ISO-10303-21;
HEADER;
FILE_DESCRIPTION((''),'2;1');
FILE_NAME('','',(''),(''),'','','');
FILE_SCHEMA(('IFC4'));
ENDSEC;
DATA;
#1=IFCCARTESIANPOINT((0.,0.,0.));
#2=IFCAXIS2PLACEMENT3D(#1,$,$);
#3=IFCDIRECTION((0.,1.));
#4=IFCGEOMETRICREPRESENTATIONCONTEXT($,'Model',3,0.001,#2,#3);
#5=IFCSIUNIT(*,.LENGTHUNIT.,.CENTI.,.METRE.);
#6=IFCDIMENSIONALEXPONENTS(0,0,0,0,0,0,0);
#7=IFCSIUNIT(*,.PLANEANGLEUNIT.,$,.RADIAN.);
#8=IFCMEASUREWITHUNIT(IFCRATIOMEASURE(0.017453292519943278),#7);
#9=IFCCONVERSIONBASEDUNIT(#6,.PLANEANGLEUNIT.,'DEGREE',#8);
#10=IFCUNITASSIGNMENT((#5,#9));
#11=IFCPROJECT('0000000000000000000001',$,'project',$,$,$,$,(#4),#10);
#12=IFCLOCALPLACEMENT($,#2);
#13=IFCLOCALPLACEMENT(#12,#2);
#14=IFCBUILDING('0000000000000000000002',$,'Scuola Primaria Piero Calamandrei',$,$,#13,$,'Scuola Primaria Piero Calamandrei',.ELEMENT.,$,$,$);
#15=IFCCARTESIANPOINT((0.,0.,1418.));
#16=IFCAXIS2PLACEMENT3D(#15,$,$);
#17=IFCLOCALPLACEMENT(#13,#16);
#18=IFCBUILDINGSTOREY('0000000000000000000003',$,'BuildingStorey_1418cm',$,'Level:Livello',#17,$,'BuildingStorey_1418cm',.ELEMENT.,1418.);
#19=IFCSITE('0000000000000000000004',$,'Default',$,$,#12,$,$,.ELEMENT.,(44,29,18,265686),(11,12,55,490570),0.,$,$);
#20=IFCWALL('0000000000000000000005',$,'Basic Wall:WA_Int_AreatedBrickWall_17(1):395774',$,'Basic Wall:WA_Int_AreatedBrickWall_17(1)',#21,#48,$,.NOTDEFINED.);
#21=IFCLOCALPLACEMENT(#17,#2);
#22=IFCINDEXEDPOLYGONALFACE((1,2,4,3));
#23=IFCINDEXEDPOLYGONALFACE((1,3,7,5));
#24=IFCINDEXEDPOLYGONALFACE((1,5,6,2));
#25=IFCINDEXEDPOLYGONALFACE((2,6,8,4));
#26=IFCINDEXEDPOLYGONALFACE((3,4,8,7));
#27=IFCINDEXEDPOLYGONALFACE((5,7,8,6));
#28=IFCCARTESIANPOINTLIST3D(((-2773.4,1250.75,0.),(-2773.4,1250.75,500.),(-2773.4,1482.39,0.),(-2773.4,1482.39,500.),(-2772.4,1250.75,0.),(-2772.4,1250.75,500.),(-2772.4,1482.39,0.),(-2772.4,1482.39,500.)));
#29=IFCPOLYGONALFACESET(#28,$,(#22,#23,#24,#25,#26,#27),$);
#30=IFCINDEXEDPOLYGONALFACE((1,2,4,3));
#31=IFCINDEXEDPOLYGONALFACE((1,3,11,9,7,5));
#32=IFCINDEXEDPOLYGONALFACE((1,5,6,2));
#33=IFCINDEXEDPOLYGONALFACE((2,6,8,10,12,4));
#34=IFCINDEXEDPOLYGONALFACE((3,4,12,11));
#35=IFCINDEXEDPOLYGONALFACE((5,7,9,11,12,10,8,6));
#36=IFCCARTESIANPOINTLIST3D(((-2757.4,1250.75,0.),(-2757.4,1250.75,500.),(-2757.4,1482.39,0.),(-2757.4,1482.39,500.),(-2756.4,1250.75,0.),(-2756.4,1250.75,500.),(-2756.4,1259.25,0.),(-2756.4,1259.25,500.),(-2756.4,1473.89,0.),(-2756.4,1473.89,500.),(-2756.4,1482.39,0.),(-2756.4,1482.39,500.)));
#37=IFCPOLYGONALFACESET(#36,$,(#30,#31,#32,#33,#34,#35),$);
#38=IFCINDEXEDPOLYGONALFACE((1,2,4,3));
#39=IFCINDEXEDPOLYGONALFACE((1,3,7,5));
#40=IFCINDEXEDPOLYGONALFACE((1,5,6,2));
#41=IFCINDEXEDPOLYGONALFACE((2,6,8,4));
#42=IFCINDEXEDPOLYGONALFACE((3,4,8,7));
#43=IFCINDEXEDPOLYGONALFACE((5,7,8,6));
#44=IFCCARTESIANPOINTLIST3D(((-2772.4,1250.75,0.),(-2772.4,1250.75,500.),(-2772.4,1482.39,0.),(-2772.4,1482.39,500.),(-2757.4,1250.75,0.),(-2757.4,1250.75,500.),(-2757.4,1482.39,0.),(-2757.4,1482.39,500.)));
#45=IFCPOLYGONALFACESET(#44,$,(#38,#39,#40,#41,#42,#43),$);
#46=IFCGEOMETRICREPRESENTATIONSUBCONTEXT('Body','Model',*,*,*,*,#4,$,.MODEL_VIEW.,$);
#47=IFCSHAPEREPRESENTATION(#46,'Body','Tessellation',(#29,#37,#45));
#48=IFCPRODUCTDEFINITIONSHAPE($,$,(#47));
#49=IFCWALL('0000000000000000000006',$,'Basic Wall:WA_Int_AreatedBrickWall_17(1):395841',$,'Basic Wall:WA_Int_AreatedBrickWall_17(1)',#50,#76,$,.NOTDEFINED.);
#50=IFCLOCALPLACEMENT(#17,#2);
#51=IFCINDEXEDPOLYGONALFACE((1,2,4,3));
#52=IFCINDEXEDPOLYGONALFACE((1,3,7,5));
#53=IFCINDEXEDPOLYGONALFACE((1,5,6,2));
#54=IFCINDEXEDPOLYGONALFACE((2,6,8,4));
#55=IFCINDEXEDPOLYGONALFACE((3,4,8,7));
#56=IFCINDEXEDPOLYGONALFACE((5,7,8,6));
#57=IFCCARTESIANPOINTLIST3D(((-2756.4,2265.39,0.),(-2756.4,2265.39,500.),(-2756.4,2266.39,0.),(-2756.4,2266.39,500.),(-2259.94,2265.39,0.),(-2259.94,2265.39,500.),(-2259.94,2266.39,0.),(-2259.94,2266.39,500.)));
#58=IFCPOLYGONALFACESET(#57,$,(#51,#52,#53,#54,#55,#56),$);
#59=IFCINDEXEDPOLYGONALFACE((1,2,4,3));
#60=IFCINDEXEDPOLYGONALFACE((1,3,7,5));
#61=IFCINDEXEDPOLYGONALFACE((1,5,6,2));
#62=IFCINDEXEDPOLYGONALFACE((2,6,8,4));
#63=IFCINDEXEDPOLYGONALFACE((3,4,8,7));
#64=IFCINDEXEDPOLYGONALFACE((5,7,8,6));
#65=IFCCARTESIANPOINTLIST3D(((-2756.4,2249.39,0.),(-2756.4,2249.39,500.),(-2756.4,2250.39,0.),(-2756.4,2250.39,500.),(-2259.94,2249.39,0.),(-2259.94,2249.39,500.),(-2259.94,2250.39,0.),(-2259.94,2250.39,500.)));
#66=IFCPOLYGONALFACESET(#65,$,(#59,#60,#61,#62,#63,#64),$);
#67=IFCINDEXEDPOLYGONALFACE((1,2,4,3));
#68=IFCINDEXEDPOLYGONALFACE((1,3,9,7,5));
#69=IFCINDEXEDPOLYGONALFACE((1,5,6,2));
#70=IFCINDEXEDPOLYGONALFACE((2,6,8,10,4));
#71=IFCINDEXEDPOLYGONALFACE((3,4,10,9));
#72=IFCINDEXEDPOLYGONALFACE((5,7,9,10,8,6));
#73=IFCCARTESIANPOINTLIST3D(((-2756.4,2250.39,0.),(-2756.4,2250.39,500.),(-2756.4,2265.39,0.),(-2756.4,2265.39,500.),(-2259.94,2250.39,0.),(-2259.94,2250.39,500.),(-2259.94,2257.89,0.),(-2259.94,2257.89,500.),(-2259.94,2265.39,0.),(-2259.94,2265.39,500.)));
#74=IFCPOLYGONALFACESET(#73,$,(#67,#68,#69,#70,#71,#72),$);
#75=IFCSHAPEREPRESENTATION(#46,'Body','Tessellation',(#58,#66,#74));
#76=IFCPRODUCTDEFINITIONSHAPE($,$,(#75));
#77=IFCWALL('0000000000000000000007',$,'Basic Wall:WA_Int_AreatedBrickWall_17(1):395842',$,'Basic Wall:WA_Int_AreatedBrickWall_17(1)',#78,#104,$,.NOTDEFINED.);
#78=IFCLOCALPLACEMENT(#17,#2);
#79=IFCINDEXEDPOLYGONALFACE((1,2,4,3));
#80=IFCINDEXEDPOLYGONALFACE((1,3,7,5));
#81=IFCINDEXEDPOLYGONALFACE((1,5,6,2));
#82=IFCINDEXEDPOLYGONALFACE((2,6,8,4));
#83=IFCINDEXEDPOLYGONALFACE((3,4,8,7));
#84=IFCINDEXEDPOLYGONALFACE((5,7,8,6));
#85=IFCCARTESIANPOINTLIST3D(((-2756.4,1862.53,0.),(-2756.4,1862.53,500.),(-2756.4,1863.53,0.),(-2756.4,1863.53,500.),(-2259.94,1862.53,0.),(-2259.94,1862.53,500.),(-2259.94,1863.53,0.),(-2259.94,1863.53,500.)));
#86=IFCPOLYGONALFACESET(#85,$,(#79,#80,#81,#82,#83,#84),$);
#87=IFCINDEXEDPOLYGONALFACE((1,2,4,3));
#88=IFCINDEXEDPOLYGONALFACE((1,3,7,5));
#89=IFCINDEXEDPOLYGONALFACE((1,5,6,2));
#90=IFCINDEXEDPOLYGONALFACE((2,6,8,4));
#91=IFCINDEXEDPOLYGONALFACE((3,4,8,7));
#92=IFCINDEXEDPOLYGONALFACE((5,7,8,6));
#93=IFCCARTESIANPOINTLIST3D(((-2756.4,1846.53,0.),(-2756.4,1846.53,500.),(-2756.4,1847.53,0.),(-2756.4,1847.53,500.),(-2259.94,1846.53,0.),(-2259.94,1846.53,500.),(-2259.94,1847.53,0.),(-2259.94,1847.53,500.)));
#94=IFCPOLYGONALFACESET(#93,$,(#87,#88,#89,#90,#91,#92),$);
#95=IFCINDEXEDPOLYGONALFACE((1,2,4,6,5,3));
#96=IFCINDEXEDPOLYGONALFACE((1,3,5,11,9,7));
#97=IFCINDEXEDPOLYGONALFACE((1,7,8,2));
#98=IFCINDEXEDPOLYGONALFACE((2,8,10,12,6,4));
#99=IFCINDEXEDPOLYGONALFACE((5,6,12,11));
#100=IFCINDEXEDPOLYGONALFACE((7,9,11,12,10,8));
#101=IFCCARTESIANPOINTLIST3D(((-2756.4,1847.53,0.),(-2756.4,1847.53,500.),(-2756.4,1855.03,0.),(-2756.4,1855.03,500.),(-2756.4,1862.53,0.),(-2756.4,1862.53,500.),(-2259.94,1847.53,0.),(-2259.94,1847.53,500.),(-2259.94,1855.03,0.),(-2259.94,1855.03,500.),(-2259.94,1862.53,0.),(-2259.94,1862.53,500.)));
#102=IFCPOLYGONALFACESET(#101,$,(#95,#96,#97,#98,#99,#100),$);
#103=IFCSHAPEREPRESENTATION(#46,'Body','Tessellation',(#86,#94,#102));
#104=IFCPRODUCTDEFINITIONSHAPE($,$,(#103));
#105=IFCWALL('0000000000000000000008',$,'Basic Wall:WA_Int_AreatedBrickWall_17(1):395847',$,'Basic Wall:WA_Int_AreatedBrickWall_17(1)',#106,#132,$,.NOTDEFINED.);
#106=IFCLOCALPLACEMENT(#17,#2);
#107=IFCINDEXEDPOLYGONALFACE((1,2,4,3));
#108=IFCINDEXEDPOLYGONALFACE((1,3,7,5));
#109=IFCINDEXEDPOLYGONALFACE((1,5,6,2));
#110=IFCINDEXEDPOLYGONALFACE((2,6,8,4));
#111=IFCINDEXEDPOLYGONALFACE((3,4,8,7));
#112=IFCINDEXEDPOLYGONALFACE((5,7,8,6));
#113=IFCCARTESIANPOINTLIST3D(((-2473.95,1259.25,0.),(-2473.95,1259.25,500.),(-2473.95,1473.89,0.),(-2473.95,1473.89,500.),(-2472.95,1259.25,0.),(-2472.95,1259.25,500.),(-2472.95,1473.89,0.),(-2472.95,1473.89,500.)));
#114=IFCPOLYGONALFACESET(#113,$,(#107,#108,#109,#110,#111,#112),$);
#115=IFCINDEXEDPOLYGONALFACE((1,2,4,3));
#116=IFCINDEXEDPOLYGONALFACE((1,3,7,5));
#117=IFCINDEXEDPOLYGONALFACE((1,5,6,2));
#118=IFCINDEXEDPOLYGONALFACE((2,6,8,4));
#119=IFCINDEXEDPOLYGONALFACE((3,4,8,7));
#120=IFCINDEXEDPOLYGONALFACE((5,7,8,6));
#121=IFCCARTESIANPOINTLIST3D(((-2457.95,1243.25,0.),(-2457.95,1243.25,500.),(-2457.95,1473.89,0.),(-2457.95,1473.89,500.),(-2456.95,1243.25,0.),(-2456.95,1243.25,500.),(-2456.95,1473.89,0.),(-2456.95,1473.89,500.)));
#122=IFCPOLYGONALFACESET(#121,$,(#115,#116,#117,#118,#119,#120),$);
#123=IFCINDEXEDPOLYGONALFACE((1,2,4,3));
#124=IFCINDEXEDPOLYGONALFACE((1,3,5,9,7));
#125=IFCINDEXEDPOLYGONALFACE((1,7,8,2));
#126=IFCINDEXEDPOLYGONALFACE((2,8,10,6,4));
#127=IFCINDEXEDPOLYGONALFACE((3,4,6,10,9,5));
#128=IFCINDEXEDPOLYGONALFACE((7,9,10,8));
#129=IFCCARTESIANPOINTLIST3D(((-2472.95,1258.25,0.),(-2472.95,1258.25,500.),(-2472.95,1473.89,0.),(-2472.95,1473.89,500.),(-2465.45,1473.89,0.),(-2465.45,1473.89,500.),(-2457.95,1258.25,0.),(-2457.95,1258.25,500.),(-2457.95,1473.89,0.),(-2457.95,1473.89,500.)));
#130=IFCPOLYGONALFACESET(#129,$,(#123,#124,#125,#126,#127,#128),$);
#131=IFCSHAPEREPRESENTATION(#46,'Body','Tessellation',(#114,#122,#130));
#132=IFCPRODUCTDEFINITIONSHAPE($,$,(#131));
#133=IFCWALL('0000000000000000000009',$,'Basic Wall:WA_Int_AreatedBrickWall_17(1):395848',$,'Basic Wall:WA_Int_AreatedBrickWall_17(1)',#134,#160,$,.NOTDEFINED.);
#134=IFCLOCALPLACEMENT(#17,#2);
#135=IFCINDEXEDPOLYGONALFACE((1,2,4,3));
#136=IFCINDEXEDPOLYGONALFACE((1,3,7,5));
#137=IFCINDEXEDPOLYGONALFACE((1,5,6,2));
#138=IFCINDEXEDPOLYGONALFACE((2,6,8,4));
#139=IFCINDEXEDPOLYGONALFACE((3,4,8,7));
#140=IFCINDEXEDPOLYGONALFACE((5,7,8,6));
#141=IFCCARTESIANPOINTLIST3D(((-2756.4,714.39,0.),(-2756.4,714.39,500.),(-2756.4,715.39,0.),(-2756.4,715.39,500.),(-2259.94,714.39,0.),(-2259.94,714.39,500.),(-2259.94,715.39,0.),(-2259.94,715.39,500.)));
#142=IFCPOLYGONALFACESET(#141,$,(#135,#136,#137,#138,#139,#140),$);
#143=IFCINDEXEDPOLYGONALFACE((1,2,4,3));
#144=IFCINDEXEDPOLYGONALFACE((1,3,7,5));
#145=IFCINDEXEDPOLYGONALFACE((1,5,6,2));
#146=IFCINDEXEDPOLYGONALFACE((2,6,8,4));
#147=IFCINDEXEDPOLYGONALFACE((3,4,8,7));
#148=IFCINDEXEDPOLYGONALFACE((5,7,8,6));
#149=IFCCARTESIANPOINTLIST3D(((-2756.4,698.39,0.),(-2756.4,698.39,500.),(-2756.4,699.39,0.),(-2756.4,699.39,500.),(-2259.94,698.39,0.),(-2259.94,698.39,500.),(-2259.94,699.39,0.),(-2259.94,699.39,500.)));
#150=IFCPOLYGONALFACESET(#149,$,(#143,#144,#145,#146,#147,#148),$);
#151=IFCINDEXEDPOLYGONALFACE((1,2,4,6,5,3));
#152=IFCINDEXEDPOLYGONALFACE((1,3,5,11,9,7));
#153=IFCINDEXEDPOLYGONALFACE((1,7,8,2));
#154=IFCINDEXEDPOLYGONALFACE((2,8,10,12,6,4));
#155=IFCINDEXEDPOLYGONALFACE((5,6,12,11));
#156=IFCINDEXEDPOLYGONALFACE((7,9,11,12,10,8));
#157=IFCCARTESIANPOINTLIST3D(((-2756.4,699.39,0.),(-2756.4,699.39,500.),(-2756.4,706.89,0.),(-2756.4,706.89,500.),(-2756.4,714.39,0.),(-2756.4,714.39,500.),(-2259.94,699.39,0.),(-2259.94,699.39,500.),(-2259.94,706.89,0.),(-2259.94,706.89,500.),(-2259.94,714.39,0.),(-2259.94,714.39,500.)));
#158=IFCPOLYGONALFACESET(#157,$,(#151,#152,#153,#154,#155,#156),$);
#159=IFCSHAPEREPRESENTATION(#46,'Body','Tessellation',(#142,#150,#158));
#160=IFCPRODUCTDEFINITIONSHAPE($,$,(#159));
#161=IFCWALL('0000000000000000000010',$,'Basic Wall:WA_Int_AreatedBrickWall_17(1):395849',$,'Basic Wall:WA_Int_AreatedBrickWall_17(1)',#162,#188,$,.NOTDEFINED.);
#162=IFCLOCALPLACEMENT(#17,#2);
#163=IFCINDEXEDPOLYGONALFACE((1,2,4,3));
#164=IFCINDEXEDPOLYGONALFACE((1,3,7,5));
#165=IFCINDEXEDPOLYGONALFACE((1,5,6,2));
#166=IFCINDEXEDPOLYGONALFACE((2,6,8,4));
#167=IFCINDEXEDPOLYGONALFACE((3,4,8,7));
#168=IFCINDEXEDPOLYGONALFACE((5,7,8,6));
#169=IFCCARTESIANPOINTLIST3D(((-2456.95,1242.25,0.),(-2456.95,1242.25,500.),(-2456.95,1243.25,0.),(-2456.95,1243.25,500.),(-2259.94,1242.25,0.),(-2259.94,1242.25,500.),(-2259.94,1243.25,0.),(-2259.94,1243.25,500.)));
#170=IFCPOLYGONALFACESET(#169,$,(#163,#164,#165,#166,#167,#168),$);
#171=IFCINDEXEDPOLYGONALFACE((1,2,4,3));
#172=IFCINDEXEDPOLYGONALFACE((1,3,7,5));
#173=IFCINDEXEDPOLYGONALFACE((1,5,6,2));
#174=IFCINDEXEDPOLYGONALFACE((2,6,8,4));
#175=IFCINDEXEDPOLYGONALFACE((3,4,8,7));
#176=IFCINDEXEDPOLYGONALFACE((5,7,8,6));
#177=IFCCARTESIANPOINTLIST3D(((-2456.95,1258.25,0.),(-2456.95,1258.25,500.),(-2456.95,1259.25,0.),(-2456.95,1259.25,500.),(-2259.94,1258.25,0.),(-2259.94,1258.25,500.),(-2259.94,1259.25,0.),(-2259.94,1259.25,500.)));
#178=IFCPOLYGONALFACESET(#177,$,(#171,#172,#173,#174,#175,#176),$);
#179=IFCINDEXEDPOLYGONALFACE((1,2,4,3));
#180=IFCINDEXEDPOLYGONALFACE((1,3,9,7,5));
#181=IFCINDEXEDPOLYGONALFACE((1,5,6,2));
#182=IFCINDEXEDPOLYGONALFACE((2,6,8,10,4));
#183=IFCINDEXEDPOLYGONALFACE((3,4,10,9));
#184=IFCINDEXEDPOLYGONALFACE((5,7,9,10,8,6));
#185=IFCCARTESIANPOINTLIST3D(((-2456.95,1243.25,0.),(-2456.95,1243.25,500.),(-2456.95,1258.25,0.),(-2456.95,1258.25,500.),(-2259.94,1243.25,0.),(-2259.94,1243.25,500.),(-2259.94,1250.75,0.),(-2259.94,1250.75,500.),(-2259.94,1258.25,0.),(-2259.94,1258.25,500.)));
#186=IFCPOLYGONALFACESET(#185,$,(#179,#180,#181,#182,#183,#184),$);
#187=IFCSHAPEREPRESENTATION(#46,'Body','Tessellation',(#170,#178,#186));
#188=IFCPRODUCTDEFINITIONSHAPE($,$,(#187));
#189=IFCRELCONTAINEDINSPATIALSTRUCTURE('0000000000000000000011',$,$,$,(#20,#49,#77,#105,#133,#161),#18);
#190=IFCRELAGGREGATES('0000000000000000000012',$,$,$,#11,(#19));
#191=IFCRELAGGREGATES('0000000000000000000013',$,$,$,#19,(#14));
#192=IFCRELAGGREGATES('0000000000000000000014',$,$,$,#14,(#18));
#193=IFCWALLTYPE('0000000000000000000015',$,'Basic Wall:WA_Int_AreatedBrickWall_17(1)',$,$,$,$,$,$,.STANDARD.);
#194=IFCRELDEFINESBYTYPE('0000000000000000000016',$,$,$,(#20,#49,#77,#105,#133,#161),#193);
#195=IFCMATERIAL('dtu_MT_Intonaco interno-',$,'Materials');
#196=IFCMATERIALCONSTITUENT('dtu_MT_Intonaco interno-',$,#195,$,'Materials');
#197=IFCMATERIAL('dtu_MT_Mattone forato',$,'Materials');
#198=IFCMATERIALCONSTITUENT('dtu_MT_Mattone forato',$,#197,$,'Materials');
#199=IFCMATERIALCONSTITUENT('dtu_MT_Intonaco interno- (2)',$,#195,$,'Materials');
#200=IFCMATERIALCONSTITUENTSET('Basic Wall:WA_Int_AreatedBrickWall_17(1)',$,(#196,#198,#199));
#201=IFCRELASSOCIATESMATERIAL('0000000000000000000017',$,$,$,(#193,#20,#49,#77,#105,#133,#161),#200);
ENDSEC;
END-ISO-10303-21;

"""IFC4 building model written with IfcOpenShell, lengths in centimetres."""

from ifc_helpers import new_model, entity, si_unit, converted_unit, direction, frame, origin, place, context, subcontext, project, spatial, indexed_curve, outline, extrude, material, constituent, constituent_set, type_object, element, save


model = new_model("IFC4")

# Units and contexts
model_context = context("Model", 3, precision=0.001, world=origin(), true_north=direction((0.0, 1.0)))
body_context = subcontext(model_context, "Body", "Model", "MODEL_VIEW")
ifc_project = project(units=[si_unit("LENGTHUNIT", "METRE", prefix="CENTI"), converted_unit("PLANEANGLEUNIT", "DEGREE", entity("IfcRatioMeasure", 0.017453292519943278), si_unit("PLANEANGLEUNIT", "RADIAN"), dimensions=[0, 0, 0, 0, 0, 0, 0])], contexts=[model_context])

# Site, building, storey
site_placement = place(None, origin())
site = spatial("IfcSite", under=ifc_project, at=site_placement, Name="Default", CompositionType="ELEMENT", RefLatitude=(44, 29, 18, 265686), RefLongitude=(11, 12, 55, 490570), RefElevation=0.0)
building_placement = place(site_placement, origin())
building = spatial("IfcBuilding", under=site, at=building_placement, Name="Scuola Primaria Piero Calamandrei", LongName="Scuola Primaria Piero Calamandrei", CompositionType="ELEMENT")
storey_placement = place(building_placement, frame((0.0, 0.0, 1418.0)))
storey = spatial("IfcBuildingStorey", under=building, at=storey_placement, Name="BuildingStorey_1418cm", ObjectType="Level:Livello", LongName="BuildingStorey_1418cm", CompositionType="ELEMENT", Elevation=1418.0)

# Shared definitions
ifc_material_1 = material(Name="dtu_MT_Intonaco interno-", Category="Materials")

# Shared definitions
ifc_constituent_1 = constituent(ifc_material_1, Name="dtu_MT_Intonaco interno-", Category="Materials")
ifc_material_2 = material(Name="dtu_MT_Mattone forato", Category="Materials")
ifc_constituent_2 = constituent(ifc_material_2, Name="dtu_MT_Mattone forato", Category="Materials")
ifc_constituent_3 = constituent(ifc_material_1, Name="dtu_MT_Intonaco interno- (2)", Category="Materials")
ifc_constituent_set_1 = constituent_set(constituents=[ifc_constituent_1, ifc_constituent_2, ifc_constituent_3], Name="Basic Wall:WA_Int_AreatedBrickWall_17(1)")
wall_type_1 = type_object("IfcWallType", Name="Basic Wall:WA_Int_AreatedBrickWall_17(1)", PredefinedType="STANDARD", material=ifc_constituent_set_1)

# Wall
wall_1_placement = place(storey_placement, frame((-2764.9, 1482.39, 0.0), z_axis=(0.0, 0.0, 1.0), x_axis=(0.0, -1.0, 0.0)))
element("IfcWall", 1, at=wall_1_placement, inside=storey, type_object=wall_type_1, material=ifc_constituent_set_1, Name="Basic Wall:WA_Int_AreatedBrickWall_17(1):395774", ObjectType="Basic Wall:WA_Int_AreatedBrickWall_17(1)", PredefinedType="NOTDEFINED", context=body_context, shape_type="SweptSolid", body=[
    extrude(outline(indexed_curve([(-0.5, -115.82), (0.5, -115.82), (0.5, 115.82), (-0.5, 115.82), (-0.5, -115.82)], self_intersect=False)), frame((115.82, -8.0, 0.0), z_axis=(0.0, 0.0, 1.0), x_axis=(0.0, 1.0, 0.0)), (0.0, 0.0, 1.0), 500.0),
    extrude(outline(indexed_curve([(-107.32, -0.33), (107.32, -0.33), (115.82, -0.33), (115.82, 0.67), (-115.82, 0.67), (-115.82, -0.33), (-107.32, -0.33)], self_intersect=False)), frame((115.82, 8.17, 0.0), z_axis=(0.0, 0.0, 1.0), x_axis=(-1.0, 0.0, 0.0)), (0.0, 0.0, 1.0), 500.0),
    extrude(outline(indexed_curve([(-115.82, -7.5), (115.82, -7.5), (115.82, 7.5), (-115.82, 7.5), (-115.82, -7.5)], self_intersect=False)), frame((115.82, 0.0, 0.0)), (0.0, 0.0, 1.0), 500.0),
])

# Walls
wall_2_placement = place(storey_placement, frame((-2259.94, 2257.89, 0.0), z_axis=(0.0, 0.0, 1.0), x_axis=(-1.0, 0.0, 0.0)))
element("IfcWall", 2, at=wall_2_placement, inside=storey, type_object=wall_type_1, material=ifc_constituent_set_1, Name="Basic Wall:WA_Int_AreatedBrickWall_17(1):395841", ObjectType="Basic Wall:WA_Int_AreatedBrickWall_17(1)", PredefinedType="NOTDEFINED", context=body_context, shape_type="SweptSolid", body=[
    extrude(outline(indexed_curve([(-0.5, -248.23), (0.5, -248.23), (0.5, 248.23), (-0.5, 248.23), (-0.5, -248.23)], self_intersect=False)), frame((248.23, -8.0, 0.0), z_axis=(0.0, 0.0, 1.0), x_axis=(0.0, 1.0, 0.0)), (0.0, 0.0, 1.0), 500.0),
    extrude(outline(indexed_curve([(-0.5, -248.23), (0.5, -248.23), (0.5, 248.23), (-0.5, 248.23), (-0.5, -248.23)], self_intersect=False)), frame((248.23, 8.0, 0.0), z_axis=(0.0, 0.0, 1.0), x_axis=(0.0, -1.0, 0.0)), (0.0, 0.0, 1.0), 500.0),
    extrude(outline(indexed_curve([(-198.59, -7.5), (297.88, -7.5), (297.88, 7.5), (-198.59, 7.5), (-198.59, 0.0), (-198.59, -7.5)], self_intersect=False)), frame((198.59, 0.0, 0.0)), (0.0, 0.0, 1.0), 500.0),
])
wall_3_placement = place(storey_placement, frame((-2259.94, 1855.03, 0.0), z_axis=(0.0, 0.0, 1.0), x_axis=(-1.0, 0.0, 0.0)))
element("IfcWall", 3, at=wall_3_placement, inside=storey, type_object=wall_type_1, material=ifc_constituent_set_1, Name="Basic Wall:WA_Int_AreatedBrickWall_17(1):395842", ObjectType="Basic Wall:WA_Int_AreatedBrickWall_17(1)", PredefinedType="NOTDEFINED", context=body_context, shape_type="SweptSolid", body=[
    extrude(outline(indexed_curve([(-0.5, -248.23), (0.5, -248.23), (0.5, 248.23), (-0.5, 248.23), (-0.5, -248.23)], self_intersect=False)), frame((248.23, -8.0, 0.0), z_axis=(0.0, 0.0, 1.0), x_axis=(0.0, 1.0, 0.0)), (0.0, 0.0, 1.0), 500.0),
    extrude(outline(indexed_curve([(-0.5, -248.23), (0.5, -248.23), (0.5, 248.23), (-0.5, 248.23), (-0.5, -248.23)], self_intersect=False)), frame((248.23, 8.0, 0.0), z_axis=(0.0, 0.0, 1.0), x_axis=(0.0, -1.0, 0.0)), (0.0, 0.0, 1.0), 500.0),
    extrude(outline(indexed_curve([(-248.23, -7.5), (248.23, -7.5), (248.23, 0.0), (248.23, 7.5), (-248.23, 7.5), (-248.23, 0.0), (-248.23, -7.5)], self_intersect=False)), frame((248.23, 0.0, 0.0)), (0.0, 0.0, 1.0), 500.0),
])
wall_4_placement = place(storey_placement, frame((-2465.45, 1473.89, 0.0), z_axis=(0.0, 0.0, 1.0), x_axis=(0.0, -1.0, 0.0)))
element("IfcWall", 4, at=wall_4_placement, inside=storey, type_object=wall_type_1, material=ifc_constituent_set_1, Name="Basic Wall:WA_Int_AreatedBrickWall_17(1):395847", ObjectType="Basic Wall:WA_Int_AreatedBrickWall_17(1)", PredefinedType="NOTDEFINED", context=body_context, shape_type="SweptSolid", body=[
    extrude(outline(indexed_curve([(-0.5, -107.32), (0.5, -107.32), (0.5, 107.32), (-0.5, 107.32), (-0.5, -107.32)], self_intersect=False)), frame((107.32, -8.0, 0.0), z_axis=(0.0, 0.0, 1.0), x_axis=(0.0, 1.0, 0.0)), (0.0, 0.0, 1.0), 500.0),
    extrude(outline(indexed_curve([(-0.5, -115.32), (0.5, -115.32), (0.5, 115.32), (-0.5, 115.32), (-0.5, -115.32)], self_intersect=False)), frame((115.32, 8.0, 0.0), z_axis=(0.0, 0.0, 1.0), x_axis=(0.0, -1.0, 0.0)), (0.0, 0.0, 1.0), 500.0),
    extrude(outline(indexed_curve([(-86.26, -7.5), (129.39, -7.5), (129.39, 7.5), (-86.26, 7.5), (-86.26, 0.0), (-86.26, -7.5)], self_intersect=False)), frame((86.26, 0.0, 0.0)), (0.0, 0.0, 1.0), 500.0),
])
wall_5_placement = place(storey_placement, frame((-2259.94, 706.89, 0.0), z_axis=(0.0, 0.0, 1.0), x_axis=(-1.0, 0.0, 0.0)))
element("IfcWall", 5, at=wall_5_placement, inside=storey, type_object=wall_type_1, material=ifc_constituent_set_1, Name="Basic Wall:WA_Int_AreatedBrickWall_17(1):395848", ObjectType="Basic Wall:WA_Int_AreatedBrickWall_17(1)", PredefinedType="NOTDEFINED", context=body_context, shape_type="SweptSolid", body=[
    extrude(outline(indexed_curve([(-0.5, -248.23), (0.5, -248.23), (0.5, 248.23), (-0.5, 248.23), (-0.5, -248.23)], self_intersect=False)), frame((248.23, -8.0, 0.0), z_axis=(0.0, 0.0, 1.0), x_axis=(0.0, 1.0, 0.0)), (0.0, 0.0, 1.0), 500.0),
    extrude(outline(indexed_curve([(-0.5, -248.23), (0.5, -248.23), (0.5, 248.23), (-0.5, 248.23), (-0.5, -248.23)], self_intersect=False)), frame((248.23, 8.0, 0.0), z_axis=(0.0, 0.0, 1.0), x_axis=(0.0, -1.0, 0.0)), (0.0, 0.0, 1.0), 500.0),
    extrude(outline(indexed_curve([(-248.23, -7.5), (248.23, -7.5), (248.23, 0.0), (248.23, 7.5), (-248.23, 7.5), (-248.23, 0.0), (-248.23, -7.5)], self_intersect=False)), frame((248.23, 0.0, 0.0)), (0.0, 0.0, 1.0), 500.0),
])
wall_6_placement = place(storey_placement, frame((-2456.95, 1250.75, 0.0)))
element("IfcWall", 6, at=wall_6_placement, inside=storey, type_object=wall_type_1, material=ifc_constituent_set_1, Name="Basic Wall:WA_Int_AreatedBrickWall_17(1):395849", ObjectType="Basic Wall:WA_Int_AreatedBrickWall_17(1)", PredefinedType="NOTDEFINED", context=body_context, shape_type="SweptSolid", body=[
    extrude(outline(indexed_curve([(-0.5, -98.5), (0.5, -98.5), (0.5, 98.5), (-0.5, 98.5), (-0.5, -98.5)], self_intersect=False)), frame((98.5, -8.0, 0.0), z_axis=(0.0, 0.0, 1.0), x_axis=(0.0, 1.0, 0.0)), (0.0, 0.0, 1.0), 500.0),
    extrude(outline(indexed_curve([(-0.5, -98.5), (0.5, -98.5), (0.5, 98.5), (-0.5, 98.5), (-0.5, -98.5)], self_intersect=False)), frame((98.5, 8.0, 0.0), z_axis=(0.0, 0.0, 1.0), x_axis=(0.0, -1.0, 0.0)), (0.0, 0.0, 1.0), 500.0),
    extrude(outline(indexed_curve([(-118.21, -7.5), (78.8, -7.5), (78.8, 0.0), (78.8, 7.5), (-118.21, 7.5), (-118.21, -7.5)], self_intersect=False)), frame((118.21, 0.0, 0.0)), (0.0, 0.0, 1.0), 500.0),
])

save(model, "model.ifc")
